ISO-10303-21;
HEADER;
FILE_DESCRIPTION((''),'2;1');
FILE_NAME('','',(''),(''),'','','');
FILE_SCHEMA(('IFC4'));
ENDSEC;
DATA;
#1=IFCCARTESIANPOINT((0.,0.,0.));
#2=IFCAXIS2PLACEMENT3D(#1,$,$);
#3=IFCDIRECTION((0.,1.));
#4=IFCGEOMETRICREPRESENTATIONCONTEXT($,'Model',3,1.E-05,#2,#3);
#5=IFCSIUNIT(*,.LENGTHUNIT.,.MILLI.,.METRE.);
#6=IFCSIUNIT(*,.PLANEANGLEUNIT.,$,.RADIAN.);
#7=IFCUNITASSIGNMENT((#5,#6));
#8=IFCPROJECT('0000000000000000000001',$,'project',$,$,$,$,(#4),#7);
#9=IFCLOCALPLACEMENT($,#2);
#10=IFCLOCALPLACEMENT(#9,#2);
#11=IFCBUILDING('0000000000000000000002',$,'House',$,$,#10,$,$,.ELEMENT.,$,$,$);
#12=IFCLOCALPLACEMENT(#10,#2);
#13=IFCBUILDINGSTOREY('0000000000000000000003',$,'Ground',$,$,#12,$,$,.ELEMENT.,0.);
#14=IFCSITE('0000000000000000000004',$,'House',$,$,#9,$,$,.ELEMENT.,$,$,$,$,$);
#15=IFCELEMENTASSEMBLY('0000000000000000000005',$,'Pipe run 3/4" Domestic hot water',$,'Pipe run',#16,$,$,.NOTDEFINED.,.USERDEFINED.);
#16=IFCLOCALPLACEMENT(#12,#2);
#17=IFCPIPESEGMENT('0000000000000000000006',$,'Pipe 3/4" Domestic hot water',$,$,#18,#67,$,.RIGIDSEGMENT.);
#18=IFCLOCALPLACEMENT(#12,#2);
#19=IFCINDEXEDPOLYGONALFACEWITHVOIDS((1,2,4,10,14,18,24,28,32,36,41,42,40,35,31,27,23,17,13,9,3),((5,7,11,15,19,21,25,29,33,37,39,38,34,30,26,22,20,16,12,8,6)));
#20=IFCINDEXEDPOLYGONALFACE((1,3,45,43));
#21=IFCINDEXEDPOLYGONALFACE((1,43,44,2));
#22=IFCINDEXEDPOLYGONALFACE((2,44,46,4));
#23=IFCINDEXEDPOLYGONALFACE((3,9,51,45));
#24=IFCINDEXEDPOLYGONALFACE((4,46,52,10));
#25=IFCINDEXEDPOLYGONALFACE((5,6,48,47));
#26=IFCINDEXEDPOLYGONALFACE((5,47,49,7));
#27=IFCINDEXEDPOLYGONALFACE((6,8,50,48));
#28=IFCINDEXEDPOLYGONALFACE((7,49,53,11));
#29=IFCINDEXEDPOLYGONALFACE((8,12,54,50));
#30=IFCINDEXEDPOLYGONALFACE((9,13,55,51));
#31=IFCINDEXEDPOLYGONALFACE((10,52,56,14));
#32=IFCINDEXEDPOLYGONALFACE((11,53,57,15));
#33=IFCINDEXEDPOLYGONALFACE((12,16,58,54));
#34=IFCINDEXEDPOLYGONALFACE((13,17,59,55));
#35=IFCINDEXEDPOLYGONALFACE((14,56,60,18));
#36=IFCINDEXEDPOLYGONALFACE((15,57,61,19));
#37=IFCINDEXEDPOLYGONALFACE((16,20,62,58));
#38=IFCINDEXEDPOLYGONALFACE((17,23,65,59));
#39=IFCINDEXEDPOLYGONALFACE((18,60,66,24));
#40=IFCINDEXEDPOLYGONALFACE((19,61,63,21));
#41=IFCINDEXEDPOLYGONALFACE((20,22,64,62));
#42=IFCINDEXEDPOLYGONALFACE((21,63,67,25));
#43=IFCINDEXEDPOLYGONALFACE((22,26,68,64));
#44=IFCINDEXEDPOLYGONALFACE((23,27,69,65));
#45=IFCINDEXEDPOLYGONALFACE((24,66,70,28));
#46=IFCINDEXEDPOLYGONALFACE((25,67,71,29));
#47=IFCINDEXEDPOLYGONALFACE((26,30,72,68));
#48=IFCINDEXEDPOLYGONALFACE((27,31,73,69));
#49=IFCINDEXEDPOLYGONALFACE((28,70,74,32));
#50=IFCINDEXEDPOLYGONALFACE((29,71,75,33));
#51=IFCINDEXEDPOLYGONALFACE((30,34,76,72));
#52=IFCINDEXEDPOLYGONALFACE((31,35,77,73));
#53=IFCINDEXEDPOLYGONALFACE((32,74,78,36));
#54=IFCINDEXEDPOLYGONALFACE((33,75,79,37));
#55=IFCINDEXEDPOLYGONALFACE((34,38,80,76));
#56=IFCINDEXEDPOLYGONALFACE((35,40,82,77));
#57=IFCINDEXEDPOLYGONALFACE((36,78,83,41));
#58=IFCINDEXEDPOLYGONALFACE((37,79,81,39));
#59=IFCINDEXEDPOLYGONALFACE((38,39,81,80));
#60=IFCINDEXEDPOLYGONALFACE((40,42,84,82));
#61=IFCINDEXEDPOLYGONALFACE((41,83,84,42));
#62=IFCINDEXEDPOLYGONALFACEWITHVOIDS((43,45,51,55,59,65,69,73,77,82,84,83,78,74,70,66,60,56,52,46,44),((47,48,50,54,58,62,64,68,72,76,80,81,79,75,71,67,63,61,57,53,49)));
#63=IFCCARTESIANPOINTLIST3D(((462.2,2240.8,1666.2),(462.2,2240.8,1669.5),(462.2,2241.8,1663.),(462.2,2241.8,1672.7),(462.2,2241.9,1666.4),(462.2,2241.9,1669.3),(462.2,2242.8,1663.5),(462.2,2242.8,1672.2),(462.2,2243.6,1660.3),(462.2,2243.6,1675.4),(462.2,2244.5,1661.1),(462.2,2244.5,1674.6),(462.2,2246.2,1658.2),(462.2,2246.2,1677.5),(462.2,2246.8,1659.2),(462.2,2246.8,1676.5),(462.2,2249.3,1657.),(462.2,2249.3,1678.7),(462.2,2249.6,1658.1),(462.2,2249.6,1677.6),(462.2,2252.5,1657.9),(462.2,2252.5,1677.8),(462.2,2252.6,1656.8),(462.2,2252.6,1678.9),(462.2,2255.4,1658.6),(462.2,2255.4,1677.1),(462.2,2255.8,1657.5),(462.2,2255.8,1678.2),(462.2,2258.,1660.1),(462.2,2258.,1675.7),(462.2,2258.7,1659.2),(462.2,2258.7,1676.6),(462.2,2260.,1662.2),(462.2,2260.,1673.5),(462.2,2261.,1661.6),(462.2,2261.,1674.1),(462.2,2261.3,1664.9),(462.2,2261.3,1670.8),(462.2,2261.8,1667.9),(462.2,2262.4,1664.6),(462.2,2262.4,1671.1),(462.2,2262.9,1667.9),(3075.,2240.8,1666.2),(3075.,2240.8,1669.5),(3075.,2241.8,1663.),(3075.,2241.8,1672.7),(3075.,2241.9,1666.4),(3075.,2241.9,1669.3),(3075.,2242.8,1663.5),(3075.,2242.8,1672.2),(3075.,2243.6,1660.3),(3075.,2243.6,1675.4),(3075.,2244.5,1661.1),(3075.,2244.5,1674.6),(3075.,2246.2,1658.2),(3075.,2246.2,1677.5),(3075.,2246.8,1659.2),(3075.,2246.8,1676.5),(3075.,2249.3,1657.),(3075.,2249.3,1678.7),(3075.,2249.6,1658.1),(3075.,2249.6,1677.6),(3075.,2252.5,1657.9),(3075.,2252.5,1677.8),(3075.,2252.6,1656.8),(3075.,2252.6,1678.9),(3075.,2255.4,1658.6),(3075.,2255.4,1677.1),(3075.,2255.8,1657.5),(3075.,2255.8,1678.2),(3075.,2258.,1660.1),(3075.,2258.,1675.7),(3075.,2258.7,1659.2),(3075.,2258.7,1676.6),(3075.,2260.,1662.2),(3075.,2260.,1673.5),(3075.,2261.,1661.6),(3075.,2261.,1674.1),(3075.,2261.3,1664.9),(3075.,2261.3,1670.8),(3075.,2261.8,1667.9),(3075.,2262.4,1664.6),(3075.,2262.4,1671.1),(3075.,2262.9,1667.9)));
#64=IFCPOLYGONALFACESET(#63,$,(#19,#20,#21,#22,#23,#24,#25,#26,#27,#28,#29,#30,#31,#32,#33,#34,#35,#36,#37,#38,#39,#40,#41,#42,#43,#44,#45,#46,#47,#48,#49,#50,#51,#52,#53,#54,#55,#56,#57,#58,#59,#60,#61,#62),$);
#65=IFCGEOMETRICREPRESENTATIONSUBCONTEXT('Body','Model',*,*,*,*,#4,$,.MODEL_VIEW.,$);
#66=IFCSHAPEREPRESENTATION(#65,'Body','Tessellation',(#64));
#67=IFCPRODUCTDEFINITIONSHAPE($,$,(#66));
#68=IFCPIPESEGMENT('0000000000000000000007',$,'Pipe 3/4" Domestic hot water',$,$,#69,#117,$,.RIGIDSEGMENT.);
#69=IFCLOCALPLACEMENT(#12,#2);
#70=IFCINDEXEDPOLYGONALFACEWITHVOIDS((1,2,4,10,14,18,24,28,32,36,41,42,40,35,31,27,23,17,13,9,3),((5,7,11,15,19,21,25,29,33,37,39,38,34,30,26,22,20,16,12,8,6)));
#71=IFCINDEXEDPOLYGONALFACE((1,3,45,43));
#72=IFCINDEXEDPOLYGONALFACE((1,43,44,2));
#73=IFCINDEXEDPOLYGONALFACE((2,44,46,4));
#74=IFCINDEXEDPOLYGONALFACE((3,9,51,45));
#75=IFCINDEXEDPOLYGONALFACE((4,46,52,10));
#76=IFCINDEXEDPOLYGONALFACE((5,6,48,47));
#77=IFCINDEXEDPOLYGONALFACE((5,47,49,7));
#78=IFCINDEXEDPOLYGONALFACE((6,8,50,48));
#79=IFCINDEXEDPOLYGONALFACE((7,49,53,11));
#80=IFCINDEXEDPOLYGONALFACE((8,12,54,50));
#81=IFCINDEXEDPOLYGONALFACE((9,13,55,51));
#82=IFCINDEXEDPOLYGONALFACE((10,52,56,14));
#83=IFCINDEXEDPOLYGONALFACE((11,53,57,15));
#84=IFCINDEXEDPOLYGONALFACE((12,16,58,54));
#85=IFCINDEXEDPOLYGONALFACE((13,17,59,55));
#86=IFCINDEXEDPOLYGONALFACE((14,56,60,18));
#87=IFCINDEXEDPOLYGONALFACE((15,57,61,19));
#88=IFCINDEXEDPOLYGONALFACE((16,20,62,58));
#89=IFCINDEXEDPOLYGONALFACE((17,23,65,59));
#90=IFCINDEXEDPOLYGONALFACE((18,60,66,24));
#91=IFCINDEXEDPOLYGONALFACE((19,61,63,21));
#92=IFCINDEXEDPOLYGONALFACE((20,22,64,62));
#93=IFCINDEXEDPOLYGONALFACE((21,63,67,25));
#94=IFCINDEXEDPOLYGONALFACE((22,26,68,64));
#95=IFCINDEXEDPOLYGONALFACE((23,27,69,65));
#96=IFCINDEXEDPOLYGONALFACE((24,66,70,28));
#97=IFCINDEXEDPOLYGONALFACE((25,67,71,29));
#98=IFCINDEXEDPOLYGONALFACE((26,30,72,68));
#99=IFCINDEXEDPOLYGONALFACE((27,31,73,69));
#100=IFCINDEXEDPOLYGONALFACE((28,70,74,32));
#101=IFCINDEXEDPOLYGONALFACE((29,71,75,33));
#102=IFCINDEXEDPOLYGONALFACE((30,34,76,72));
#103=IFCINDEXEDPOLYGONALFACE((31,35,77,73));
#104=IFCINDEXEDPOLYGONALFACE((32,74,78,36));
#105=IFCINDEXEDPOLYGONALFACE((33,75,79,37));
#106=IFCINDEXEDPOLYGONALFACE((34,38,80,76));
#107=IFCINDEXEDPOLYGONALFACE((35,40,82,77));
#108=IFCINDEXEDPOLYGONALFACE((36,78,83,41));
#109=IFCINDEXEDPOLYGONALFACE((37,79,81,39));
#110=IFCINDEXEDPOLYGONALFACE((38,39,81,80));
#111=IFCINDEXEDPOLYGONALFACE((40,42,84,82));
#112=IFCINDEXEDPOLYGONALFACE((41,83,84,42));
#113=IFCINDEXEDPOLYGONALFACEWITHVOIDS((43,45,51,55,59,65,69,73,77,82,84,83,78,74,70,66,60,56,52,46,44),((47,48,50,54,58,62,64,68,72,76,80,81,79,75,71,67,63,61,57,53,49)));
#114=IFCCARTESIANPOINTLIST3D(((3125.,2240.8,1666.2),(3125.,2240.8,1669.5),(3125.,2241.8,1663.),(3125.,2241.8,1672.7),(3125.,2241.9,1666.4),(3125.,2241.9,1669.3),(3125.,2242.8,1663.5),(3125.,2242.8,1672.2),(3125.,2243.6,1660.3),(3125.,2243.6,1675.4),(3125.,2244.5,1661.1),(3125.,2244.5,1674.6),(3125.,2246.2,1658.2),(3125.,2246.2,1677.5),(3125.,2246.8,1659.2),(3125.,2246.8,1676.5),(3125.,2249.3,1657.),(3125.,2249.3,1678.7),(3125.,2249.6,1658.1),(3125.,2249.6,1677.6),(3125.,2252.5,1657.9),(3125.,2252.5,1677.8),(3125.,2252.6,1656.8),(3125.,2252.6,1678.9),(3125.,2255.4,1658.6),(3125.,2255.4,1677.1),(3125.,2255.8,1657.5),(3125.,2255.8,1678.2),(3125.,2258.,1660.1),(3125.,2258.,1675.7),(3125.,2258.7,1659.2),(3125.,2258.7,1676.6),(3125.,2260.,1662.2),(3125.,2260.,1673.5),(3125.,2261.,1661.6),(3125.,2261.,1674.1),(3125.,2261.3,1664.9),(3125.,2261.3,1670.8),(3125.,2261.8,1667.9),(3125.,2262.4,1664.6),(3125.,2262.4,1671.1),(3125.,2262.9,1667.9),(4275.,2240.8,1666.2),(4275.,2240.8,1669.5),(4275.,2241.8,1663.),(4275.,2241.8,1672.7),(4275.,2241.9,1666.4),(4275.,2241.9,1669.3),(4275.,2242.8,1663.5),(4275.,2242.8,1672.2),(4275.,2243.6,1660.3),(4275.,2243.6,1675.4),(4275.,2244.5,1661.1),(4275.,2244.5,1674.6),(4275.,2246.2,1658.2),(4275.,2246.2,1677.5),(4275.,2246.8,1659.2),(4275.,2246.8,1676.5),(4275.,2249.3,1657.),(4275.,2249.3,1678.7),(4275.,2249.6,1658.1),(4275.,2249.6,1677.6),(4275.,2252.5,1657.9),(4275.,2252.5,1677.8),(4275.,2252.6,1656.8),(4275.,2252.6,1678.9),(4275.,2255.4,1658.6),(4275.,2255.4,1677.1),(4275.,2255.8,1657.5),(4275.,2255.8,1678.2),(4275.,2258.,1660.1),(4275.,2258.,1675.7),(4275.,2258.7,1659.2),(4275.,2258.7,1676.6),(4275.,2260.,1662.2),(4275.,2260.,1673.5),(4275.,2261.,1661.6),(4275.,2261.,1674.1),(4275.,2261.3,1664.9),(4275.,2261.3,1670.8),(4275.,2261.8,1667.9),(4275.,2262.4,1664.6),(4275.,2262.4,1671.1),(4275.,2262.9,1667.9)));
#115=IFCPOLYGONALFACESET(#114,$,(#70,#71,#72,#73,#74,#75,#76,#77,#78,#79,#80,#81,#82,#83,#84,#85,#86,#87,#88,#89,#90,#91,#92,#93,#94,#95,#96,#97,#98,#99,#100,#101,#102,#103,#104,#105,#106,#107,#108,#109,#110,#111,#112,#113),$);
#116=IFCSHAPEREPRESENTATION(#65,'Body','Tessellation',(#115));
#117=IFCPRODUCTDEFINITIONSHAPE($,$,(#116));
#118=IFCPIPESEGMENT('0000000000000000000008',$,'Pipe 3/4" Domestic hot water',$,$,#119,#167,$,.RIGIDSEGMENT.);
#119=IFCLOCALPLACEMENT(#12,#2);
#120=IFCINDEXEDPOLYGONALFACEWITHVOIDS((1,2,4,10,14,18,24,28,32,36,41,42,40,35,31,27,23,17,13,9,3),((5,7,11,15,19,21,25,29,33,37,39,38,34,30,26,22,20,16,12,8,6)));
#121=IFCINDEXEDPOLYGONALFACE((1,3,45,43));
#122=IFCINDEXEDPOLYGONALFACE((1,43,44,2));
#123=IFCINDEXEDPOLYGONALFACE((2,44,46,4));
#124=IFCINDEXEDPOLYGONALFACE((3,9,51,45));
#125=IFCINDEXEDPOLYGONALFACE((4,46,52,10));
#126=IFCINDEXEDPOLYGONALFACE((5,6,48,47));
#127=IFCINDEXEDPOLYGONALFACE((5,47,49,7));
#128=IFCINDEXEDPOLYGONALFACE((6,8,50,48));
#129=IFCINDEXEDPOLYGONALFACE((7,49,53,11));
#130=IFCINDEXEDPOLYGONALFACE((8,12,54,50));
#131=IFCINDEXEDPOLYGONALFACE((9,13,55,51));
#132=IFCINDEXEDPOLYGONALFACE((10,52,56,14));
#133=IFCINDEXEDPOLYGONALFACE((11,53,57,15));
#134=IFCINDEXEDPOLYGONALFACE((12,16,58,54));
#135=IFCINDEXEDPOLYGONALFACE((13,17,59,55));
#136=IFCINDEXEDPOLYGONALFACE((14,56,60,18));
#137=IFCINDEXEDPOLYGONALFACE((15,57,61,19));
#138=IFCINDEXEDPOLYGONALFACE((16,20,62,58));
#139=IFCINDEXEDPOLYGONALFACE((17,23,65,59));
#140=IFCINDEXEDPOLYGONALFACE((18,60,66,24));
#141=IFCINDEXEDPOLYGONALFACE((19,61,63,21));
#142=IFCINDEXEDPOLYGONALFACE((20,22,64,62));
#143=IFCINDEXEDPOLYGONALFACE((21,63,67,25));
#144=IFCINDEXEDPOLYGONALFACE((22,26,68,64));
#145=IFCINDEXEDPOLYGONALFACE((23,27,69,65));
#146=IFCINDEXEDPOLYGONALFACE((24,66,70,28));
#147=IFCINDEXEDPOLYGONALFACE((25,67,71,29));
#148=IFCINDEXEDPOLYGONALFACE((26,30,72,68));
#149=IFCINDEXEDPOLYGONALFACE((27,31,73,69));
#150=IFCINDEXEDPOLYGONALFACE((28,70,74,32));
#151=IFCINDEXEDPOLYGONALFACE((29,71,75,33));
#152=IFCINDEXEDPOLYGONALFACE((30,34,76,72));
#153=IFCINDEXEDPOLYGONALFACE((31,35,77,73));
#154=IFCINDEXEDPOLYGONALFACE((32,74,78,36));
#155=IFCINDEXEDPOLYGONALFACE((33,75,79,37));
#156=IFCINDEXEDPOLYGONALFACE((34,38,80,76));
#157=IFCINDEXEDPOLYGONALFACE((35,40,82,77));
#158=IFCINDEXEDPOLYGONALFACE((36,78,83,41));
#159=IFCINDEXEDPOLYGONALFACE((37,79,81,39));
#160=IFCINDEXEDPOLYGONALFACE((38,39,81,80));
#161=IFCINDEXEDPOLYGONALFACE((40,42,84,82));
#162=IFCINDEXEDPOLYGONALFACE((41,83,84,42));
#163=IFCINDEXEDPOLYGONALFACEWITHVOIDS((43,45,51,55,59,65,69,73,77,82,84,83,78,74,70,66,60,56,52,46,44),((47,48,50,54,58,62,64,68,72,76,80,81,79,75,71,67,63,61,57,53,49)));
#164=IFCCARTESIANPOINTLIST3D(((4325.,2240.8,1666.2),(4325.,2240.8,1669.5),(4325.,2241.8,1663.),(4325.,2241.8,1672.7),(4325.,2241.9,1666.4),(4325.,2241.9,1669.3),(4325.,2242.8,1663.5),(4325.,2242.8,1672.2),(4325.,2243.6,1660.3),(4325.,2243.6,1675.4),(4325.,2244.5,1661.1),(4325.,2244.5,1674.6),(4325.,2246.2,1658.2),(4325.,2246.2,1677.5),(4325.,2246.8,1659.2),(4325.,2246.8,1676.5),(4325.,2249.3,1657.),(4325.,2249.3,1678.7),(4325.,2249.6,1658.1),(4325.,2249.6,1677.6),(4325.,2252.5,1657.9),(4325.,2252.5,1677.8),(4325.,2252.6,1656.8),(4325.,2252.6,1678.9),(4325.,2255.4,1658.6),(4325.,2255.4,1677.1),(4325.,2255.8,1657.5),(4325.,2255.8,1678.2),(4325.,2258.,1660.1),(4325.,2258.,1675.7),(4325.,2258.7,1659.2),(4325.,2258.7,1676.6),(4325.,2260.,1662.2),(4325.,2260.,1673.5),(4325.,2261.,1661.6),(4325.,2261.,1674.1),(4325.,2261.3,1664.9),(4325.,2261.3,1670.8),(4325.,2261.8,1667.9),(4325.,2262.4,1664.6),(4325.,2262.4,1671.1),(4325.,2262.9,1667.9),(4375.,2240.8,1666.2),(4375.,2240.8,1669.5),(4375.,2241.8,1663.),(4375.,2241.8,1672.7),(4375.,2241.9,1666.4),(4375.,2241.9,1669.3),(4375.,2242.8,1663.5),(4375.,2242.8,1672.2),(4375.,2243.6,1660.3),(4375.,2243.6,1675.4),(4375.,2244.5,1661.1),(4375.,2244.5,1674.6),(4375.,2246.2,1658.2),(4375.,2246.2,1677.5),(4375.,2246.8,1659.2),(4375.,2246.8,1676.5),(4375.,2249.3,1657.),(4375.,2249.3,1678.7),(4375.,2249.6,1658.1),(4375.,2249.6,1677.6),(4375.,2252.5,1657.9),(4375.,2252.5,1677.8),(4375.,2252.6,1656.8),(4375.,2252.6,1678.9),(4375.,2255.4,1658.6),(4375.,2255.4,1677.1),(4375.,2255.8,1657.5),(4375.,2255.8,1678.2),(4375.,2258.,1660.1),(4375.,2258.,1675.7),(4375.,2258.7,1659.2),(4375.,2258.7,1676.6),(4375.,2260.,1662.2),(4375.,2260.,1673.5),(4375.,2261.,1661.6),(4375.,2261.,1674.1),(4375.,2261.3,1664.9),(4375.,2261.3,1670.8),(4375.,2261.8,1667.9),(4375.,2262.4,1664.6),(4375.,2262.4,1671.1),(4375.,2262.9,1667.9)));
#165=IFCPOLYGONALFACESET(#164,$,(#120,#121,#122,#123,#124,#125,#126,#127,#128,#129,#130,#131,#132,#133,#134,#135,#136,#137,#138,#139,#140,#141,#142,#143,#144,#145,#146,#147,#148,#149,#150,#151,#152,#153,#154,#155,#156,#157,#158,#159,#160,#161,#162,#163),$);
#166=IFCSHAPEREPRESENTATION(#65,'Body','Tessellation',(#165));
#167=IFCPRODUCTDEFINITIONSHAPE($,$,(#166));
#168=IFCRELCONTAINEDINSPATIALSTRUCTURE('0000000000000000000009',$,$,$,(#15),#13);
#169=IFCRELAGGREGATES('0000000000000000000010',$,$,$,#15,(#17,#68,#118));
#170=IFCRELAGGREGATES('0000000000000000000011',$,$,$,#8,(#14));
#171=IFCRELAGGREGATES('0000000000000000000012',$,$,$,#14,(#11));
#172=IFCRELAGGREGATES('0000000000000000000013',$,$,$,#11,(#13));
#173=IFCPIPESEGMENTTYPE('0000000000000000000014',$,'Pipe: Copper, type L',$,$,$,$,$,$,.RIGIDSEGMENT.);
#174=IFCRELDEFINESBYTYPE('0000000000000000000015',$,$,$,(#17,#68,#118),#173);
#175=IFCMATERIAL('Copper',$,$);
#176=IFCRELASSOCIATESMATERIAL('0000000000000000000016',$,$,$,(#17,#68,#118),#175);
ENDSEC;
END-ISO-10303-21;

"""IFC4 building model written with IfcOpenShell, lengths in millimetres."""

from ifc_helpers import new_model, si_unit, direction, frame, origin, origin_with_axes, origin_2d, place, context, subcontext, project, spatial, hollow_circle, extrude, material, type_object, element, aggregate, save


model = new_model("IFC4")

# Units and contexts
model_context = context("Model", 3, precision=1e-05, world=origin(), true_north=direction((0.0, 1.0)))
body_context = subcontext(model_context, "Body", "Model", "MODEL_VIEW")
ifc_project = project(units=[si_unit("LENGTHUNIT", "METRE", prefix="MILLI"), si_unit("PLANEANGLEUNIT", "RADIAN")], contexts=[model_context])

# Site, building, storey
site_placement = place(None, origin())
site = spatial("IfcSite", under=ifc_project, at=site_placement, Name="House", CompositionType="ELEMENT")
building_placement = place(site_placement, origin())
building = spatial("IfcBuilding", under=site, at=building_placement, Name="House", CompositionType="ELEMENT")
storey_placement = place(building_placement, origin())
storey = spatial("IfcBuildingStorey", under=building, at=storey_placement, Name="Ground", CompositionType="ELEMENT", Elevation=0.0)

# Element assembly, pipe segments
ifc_material = material(Name="Copper")
pipe_segment_type = type_object("IfcPipeSegmentType", Name="Pipe: Copper, type L", PredefinedType="RIGIDSEGMENT")
assembly_1_placement = place(storey_placement, origin_with_axes())
assembly_1 = element("IfcElementAssembly", 1, at=assembly_1_placement, inside=storey, Name="Pipe run 3/4\" Domestic hot water", ObjectType="Pipe run", AssemblyPlace="NOTDEFINED", PredefinedType="USERDEFINED")
pipe_segment_1_placement = place(storey_placement, origin_with_axes())
pipe_segment_1 = element("IfcPipeSegment", 2, at=pipe_segment_1_placement, type_object=pipe_segment_type, material=ifc_material, Name="Pipe 3/4\" Domestic hot water", PredefinedType="RIGIDSEGMENT", context=body_context, shape_type="SweptSolid", body=[
    extrude(hollow_circle(Radius=11.1, WallThickness=1.1, at=origin_2d()), frame((462.2, 2251.8, 1667.9), z_axis=(1.0, 0.0, 0.0), x_axis=(0.0, 1.0, 0.0)), (0.0, 0.0, 1.0), 2612.8),
])
pipe_segment_2_placement = place(storey_placement, origin_with_axes())
pipe_segment_2 = element("IfcPipeSegment", 3, at=pipe_segment_2_placement, type_object=pipe_segment_type, material=ifc_material, Name="Pipe 3/4\" Domestic hot water", PredefinedType="RIGIDSEGMENT", context=body_context, shape_type="SweptSolid", body=[
    extrude(hollow_circle(Radius=11.1, WallThickness=1.1, at=origin_2d()), frame((3125.0, 2251.8, 1667.9), z_axis=(1.0, 0.0, 0.0), x_axis=(0.0, 1.0, 0.0)), (0.0, 0.0, 1.0), 1150.0),
])
pipe_segment_3_placement = place(storey_placement, origin_with_axes())
pipe_segment_3 = element("IfcPipeSegment", 4, at=pipe_segment_3_placement, type_object=pipe_segment_type, material=ifc_material, Name="Pipe 3/4\" Domestic hot water", PredefinedType="RIGIDSEGMENT", context=body_context, shape_type="SweptSolid", body=[
    extrude(hollow_circle(Radius=11.1, WallThickness=1.1, at=origin_2d()), frame((4325.0, 2251.8, 1667.9), z_axis=(1.0, 0.0, 0.0), x_axis=(0.0, 1.0, 0.0)), (0.0, 0.0, 1.0), 50.0),
])

aggregate(assembly_1, [pipe_segment_1, pipe_segment_2, pipe_segment_3])

save(model, "model.ifc")
